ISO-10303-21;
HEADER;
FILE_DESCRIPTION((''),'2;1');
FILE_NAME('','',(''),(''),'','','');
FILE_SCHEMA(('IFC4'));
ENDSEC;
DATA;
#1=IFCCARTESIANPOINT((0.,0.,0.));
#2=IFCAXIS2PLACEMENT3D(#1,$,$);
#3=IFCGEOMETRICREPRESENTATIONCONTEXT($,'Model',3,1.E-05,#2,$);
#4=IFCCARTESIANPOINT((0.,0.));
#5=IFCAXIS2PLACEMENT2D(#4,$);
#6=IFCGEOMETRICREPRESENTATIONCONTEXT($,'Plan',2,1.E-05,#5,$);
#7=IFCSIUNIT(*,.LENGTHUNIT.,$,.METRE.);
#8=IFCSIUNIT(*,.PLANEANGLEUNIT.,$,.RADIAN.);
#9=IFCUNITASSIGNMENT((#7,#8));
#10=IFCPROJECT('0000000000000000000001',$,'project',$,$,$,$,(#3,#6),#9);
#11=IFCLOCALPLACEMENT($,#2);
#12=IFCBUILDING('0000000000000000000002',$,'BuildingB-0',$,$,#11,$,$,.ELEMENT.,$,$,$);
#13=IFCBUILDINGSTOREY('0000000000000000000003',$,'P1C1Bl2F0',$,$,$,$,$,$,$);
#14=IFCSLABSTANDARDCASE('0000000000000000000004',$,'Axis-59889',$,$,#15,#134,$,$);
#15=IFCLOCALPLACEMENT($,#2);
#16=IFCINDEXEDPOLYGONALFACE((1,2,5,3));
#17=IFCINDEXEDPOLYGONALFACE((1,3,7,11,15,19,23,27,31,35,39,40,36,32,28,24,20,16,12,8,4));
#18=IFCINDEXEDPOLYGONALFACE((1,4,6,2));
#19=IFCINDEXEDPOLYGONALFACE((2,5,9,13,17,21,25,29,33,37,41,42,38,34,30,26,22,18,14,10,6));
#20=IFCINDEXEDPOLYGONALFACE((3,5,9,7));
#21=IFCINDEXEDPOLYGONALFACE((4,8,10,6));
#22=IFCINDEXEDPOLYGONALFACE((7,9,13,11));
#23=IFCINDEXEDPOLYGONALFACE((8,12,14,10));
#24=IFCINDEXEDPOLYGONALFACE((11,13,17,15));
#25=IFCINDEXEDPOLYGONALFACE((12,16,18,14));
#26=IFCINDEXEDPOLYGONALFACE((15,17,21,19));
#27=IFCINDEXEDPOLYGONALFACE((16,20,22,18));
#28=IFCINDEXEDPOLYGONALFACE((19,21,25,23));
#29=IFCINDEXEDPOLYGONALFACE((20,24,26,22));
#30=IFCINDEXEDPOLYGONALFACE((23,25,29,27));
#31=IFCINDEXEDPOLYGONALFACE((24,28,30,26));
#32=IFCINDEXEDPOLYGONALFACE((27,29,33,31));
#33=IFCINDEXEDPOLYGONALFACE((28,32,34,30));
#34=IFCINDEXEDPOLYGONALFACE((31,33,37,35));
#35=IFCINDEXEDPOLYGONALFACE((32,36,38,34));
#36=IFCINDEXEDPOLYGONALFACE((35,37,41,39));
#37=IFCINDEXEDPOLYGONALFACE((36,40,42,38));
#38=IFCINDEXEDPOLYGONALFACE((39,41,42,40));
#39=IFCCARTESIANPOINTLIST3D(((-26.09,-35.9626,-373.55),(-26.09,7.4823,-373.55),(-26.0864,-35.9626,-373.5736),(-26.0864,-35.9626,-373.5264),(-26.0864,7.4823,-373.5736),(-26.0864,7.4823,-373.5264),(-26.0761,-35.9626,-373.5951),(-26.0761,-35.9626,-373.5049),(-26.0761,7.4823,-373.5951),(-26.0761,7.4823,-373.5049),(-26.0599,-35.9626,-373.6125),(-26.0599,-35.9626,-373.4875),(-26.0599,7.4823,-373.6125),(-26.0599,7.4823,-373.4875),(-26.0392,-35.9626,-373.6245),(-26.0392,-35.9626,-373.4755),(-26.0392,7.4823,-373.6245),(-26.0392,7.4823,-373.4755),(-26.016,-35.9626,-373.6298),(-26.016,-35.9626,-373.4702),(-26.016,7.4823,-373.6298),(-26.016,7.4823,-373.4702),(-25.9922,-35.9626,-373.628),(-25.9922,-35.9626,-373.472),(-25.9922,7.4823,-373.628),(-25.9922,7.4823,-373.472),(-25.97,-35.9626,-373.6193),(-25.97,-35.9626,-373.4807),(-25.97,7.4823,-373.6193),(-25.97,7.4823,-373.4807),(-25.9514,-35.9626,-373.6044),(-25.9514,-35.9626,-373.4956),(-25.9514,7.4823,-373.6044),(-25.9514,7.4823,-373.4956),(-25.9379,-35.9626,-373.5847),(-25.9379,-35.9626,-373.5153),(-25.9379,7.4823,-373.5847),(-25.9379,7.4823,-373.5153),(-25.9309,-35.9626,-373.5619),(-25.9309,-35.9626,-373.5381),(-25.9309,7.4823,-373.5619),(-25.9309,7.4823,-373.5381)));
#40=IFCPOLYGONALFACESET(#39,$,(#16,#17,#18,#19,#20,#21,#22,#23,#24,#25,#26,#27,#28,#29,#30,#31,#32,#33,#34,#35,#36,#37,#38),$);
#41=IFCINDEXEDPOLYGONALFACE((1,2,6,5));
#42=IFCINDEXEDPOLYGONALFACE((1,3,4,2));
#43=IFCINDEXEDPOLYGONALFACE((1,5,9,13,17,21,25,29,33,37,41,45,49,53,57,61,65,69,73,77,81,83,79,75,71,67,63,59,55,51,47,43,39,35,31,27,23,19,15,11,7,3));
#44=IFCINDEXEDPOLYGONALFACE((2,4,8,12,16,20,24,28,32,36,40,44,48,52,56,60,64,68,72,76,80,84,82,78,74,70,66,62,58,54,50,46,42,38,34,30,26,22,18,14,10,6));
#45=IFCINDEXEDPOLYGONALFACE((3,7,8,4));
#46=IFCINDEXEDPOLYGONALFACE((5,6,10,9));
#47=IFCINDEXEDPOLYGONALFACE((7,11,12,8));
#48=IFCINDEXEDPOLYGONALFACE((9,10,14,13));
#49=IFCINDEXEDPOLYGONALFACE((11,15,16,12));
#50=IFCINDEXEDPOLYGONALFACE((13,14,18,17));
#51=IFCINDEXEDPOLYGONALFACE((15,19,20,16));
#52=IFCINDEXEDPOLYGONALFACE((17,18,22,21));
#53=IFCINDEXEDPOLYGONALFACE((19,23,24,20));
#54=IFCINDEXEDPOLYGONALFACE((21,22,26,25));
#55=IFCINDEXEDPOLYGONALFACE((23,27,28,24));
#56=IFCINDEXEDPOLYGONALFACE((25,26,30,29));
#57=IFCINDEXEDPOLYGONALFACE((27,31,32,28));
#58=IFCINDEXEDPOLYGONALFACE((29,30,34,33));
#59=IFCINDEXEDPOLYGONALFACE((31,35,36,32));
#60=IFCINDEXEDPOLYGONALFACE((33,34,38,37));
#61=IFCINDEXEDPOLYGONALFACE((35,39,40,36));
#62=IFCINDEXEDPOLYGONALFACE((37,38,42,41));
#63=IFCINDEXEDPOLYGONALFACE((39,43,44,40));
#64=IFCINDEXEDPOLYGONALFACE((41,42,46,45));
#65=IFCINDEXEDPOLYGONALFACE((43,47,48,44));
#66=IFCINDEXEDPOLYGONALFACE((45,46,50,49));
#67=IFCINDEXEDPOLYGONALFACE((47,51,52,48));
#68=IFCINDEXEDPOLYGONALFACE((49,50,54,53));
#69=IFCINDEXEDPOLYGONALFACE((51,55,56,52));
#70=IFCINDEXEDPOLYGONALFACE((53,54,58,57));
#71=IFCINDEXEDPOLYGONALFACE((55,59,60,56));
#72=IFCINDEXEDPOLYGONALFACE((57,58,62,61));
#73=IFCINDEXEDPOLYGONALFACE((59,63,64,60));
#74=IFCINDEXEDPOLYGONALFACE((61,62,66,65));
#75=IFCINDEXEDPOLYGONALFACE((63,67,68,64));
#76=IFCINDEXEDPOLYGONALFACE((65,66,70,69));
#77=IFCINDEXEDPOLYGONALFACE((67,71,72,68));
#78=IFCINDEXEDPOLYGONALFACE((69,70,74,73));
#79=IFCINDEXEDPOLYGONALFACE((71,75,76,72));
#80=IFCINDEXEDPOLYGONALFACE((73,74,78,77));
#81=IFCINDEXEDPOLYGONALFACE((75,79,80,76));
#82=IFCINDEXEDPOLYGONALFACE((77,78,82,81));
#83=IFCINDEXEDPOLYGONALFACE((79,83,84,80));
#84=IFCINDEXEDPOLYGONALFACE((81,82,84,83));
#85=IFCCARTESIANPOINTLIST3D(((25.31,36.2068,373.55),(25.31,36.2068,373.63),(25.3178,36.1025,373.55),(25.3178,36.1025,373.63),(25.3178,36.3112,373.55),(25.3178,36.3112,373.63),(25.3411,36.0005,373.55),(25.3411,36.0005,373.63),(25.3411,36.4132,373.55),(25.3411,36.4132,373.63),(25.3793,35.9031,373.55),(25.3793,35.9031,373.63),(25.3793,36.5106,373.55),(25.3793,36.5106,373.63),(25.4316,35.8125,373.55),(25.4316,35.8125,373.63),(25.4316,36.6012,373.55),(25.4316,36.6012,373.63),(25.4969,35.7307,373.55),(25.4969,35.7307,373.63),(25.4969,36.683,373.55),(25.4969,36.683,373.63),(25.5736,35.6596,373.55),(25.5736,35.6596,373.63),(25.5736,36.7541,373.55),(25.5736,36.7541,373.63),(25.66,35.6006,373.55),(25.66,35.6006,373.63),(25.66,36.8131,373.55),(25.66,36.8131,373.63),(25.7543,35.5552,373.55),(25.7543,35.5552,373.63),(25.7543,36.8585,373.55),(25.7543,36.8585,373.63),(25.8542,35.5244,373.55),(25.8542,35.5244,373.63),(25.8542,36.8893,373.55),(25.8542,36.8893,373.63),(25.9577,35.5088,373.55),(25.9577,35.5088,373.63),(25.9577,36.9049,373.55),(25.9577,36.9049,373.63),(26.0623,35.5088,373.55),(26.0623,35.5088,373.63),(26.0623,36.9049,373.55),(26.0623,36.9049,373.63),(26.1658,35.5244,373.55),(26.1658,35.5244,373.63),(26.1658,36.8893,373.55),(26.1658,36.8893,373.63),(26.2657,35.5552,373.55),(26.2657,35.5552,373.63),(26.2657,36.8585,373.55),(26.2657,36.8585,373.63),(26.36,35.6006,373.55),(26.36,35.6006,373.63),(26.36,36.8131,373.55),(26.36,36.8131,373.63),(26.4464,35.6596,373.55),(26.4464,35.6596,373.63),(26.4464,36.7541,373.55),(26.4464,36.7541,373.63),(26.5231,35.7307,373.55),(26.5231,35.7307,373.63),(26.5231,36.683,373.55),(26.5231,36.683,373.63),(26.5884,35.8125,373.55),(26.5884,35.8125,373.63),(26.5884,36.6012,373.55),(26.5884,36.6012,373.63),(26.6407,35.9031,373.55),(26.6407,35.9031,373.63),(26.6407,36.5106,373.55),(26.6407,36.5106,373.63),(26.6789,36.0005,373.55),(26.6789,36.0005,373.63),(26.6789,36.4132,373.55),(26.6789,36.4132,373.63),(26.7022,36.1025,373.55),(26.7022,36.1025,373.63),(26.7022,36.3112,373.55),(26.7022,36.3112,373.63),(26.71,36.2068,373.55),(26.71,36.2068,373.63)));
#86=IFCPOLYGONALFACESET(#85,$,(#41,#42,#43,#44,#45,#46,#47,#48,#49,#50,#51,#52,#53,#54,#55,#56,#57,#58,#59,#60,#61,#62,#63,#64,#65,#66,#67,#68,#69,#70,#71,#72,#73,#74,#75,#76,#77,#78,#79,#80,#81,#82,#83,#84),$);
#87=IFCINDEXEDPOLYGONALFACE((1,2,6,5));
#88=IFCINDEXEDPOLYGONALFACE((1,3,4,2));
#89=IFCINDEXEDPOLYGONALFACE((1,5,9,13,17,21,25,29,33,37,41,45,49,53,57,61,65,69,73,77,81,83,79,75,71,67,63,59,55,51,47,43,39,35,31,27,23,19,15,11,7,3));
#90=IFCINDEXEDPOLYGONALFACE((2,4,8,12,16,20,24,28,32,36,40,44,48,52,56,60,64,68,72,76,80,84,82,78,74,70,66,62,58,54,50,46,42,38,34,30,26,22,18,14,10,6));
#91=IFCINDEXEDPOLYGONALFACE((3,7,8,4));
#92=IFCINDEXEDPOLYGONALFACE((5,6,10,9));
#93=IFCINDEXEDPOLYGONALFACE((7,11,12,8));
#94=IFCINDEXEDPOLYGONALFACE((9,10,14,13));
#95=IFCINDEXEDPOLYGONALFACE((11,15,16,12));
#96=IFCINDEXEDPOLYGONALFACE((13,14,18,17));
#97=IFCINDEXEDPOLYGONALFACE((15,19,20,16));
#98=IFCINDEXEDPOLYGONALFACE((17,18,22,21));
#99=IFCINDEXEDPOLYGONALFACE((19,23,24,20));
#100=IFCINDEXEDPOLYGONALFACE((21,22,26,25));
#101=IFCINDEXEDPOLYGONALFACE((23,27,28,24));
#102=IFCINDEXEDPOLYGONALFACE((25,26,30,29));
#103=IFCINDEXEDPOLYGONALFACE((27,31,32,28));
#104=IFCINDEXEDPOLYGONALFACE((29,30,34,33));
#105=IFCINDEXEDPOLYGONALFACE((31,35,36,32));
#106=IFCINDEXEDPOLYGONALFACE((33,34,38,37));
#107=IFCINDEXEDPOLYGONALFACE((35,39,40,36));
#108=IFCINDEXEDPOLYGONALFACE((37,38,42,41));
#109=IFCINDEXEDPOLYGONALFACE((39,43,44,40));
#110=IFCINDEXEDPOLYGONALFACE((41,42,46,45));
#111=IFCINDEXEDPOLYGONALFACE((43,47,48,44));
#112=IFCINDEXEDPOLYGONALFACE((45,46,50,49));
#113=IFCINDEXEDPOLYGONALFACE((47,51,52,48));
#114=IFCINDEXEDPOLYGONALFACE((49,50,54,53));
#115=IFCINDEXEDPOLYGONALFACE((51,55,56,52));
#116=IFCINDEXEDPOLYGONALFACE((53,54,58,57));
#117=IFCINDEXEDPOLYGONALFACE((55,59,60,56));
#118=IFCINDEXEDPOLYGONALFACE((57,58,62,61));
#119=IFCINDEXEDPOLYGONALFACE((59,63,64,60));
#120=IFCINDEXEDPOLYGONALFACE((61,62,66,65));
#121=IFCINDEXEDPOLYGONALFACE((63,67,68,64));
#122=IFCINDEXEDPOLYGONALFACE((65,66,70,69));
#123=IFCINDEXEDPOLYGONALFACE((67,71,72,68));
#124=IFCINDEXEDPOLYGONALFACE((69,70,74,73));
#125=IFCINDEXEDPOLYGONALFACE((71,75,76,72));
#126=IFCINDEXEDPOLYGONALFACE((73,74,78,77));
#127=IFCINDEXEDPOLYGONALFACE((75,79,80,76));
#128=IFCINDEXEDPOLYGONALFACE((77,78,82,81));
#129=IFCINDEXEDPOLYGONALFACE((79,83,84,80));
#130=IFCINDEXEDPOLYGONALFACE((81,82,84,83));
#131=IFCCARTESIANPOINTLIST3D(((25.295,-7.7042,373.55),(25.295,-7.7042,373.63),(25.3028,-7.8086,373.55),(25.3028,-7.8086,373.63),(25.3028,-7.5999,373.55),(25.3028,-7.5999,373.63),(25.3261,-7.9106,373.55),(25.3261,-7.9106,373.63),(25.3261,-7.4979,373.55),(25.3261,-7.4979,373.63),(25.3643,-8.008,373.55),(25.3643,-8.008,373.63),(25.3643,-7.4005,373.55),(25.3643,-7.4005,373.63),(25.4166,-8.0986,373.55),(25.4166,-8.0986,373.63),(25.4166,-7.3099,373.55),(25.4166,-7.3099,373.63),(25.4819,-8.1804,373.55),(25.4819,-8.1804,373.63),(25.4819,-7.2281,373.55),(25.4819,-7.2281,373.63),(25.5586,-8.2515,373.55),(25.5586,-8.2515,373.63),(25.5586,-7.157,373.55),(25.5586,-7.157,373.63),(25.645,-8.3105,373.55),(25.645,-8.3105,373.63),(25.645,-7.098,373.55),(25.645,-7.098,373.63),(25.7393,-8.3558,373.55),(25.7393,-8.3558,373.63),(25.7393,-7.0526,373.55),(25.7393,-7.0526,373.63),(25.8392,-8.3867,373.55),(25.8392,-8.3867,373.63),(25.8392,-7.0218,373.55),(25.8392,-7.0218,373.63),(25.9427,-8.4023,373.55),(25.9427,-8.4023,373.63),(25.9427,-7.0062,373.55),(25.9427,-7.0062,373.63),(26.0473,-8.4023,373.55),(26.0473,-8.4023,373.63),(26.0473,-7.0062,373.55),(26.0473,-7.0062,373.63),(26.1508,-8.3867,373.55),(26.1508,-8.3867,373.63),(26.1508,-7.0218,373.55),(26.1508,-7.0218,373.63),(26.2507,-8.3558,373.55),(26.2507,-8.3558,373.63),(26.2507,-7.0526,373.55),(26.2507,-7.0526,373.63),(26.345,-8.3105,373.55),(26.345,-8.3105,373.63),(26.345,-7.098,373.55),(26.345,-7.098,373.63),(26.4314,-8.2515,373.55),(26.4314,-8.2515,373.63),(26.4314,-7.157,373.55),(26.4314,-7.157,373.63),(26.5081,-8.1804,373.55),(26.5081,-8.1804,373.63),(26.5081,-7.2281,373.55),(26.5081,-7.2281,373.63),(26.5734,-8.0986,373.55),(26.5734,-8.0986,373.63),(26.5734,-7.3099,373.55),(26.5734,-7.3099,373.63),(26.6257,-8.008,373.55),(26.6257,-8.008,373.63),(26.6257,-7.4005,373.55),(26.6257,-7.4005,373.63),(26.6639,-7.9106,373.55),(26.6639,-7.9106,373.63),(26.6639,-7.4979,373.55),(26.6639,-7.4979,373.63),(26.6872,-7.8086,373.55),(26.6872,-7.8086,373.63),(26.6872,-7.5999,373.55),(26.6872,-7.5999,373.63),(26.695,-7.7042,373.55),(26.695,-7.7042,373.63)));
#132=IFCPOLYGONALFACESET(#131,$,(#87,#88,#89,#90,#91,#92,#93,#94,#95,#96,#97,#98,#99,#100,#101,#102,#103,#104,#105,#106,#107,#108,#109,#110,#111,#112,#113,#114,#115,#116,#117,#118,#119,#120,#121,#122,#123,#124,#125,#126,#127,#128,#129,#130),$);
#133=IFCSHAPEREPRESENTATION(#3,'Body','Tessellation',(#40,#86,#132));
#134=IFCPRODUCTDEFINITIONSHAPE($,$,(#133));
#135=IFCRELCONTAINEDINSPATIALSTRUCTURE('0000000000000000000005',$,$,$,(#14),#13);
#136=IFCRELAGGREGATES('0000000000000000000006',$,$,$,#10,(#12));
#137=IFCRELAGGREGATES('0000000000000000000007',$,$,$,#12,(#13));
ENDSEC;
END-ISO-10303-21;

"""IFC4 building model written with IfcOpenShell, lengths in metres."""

from ifc_helpers import new_model, entity, si_unit, frame, origin, origin_2d, place, context, project, spatial, circle, extrude, element, save


model = new_model("IFC4")

# Units and contexts
model_context = context("Model", 3, precision=1e-05, world=origin())
plan_context = context("Plan", 2, precision=1e-05, world=origin_2d())
ifc_project = project(units=[si_unit("LENGTHUNIT", "METRE"), si_unit("PLANEANGLEUNIT", "RADIAN")], contexts=[model_context, plan_context])

# Building, storey
building_placement = place(None, origin())
building = spatial("IfcBuilding", under=ifc_project, at=building_placement, Name="BuildingB-0", CompositionType="ELEMENT")
storey = spatial("IfcBuildingStorey", under=building, Name="P1C1Bl2F0")

# Slab
element("IfcSlabStandardCase", 1, inside=storey, Name="Axis-59889", context=model_context, shape_type="AdvancedSweptSolid", body=[
    entity("IfcSurfaceCurveSweptAreaSolid", entity("IfcCircleProfileDef", "AREA", None, None, 0.08), None, entity("IfcPolyline", [entity("IfcCartesianPoint", [26.01, 35.9626, 373.55]), entity("IfcCartesianPoint", [26.01, -7.4823, 373.55])]), None, None, entity("IfcPlane", entity("IfcAxis2Placement3D", entity("IfcCartesianPoint", [26.01, 35.9626, 373.55]), entity("IfcDirection", [0.0, 0.0, 1.0]), entity("IfcDirection", [1.0, 0.0, 0.0])))),
    extrude(circle(Radius=0.7), frame((26.01, 36.2068, 373.55)), (0.0, 0.0, 1.0), 0.08),
    extrude(circle(Radius=0.7), frame((25.995, -7.7042, 373.55)), (0.0, 0.0, 1.0), 0.08),
])

save(model, "model.ifc")
